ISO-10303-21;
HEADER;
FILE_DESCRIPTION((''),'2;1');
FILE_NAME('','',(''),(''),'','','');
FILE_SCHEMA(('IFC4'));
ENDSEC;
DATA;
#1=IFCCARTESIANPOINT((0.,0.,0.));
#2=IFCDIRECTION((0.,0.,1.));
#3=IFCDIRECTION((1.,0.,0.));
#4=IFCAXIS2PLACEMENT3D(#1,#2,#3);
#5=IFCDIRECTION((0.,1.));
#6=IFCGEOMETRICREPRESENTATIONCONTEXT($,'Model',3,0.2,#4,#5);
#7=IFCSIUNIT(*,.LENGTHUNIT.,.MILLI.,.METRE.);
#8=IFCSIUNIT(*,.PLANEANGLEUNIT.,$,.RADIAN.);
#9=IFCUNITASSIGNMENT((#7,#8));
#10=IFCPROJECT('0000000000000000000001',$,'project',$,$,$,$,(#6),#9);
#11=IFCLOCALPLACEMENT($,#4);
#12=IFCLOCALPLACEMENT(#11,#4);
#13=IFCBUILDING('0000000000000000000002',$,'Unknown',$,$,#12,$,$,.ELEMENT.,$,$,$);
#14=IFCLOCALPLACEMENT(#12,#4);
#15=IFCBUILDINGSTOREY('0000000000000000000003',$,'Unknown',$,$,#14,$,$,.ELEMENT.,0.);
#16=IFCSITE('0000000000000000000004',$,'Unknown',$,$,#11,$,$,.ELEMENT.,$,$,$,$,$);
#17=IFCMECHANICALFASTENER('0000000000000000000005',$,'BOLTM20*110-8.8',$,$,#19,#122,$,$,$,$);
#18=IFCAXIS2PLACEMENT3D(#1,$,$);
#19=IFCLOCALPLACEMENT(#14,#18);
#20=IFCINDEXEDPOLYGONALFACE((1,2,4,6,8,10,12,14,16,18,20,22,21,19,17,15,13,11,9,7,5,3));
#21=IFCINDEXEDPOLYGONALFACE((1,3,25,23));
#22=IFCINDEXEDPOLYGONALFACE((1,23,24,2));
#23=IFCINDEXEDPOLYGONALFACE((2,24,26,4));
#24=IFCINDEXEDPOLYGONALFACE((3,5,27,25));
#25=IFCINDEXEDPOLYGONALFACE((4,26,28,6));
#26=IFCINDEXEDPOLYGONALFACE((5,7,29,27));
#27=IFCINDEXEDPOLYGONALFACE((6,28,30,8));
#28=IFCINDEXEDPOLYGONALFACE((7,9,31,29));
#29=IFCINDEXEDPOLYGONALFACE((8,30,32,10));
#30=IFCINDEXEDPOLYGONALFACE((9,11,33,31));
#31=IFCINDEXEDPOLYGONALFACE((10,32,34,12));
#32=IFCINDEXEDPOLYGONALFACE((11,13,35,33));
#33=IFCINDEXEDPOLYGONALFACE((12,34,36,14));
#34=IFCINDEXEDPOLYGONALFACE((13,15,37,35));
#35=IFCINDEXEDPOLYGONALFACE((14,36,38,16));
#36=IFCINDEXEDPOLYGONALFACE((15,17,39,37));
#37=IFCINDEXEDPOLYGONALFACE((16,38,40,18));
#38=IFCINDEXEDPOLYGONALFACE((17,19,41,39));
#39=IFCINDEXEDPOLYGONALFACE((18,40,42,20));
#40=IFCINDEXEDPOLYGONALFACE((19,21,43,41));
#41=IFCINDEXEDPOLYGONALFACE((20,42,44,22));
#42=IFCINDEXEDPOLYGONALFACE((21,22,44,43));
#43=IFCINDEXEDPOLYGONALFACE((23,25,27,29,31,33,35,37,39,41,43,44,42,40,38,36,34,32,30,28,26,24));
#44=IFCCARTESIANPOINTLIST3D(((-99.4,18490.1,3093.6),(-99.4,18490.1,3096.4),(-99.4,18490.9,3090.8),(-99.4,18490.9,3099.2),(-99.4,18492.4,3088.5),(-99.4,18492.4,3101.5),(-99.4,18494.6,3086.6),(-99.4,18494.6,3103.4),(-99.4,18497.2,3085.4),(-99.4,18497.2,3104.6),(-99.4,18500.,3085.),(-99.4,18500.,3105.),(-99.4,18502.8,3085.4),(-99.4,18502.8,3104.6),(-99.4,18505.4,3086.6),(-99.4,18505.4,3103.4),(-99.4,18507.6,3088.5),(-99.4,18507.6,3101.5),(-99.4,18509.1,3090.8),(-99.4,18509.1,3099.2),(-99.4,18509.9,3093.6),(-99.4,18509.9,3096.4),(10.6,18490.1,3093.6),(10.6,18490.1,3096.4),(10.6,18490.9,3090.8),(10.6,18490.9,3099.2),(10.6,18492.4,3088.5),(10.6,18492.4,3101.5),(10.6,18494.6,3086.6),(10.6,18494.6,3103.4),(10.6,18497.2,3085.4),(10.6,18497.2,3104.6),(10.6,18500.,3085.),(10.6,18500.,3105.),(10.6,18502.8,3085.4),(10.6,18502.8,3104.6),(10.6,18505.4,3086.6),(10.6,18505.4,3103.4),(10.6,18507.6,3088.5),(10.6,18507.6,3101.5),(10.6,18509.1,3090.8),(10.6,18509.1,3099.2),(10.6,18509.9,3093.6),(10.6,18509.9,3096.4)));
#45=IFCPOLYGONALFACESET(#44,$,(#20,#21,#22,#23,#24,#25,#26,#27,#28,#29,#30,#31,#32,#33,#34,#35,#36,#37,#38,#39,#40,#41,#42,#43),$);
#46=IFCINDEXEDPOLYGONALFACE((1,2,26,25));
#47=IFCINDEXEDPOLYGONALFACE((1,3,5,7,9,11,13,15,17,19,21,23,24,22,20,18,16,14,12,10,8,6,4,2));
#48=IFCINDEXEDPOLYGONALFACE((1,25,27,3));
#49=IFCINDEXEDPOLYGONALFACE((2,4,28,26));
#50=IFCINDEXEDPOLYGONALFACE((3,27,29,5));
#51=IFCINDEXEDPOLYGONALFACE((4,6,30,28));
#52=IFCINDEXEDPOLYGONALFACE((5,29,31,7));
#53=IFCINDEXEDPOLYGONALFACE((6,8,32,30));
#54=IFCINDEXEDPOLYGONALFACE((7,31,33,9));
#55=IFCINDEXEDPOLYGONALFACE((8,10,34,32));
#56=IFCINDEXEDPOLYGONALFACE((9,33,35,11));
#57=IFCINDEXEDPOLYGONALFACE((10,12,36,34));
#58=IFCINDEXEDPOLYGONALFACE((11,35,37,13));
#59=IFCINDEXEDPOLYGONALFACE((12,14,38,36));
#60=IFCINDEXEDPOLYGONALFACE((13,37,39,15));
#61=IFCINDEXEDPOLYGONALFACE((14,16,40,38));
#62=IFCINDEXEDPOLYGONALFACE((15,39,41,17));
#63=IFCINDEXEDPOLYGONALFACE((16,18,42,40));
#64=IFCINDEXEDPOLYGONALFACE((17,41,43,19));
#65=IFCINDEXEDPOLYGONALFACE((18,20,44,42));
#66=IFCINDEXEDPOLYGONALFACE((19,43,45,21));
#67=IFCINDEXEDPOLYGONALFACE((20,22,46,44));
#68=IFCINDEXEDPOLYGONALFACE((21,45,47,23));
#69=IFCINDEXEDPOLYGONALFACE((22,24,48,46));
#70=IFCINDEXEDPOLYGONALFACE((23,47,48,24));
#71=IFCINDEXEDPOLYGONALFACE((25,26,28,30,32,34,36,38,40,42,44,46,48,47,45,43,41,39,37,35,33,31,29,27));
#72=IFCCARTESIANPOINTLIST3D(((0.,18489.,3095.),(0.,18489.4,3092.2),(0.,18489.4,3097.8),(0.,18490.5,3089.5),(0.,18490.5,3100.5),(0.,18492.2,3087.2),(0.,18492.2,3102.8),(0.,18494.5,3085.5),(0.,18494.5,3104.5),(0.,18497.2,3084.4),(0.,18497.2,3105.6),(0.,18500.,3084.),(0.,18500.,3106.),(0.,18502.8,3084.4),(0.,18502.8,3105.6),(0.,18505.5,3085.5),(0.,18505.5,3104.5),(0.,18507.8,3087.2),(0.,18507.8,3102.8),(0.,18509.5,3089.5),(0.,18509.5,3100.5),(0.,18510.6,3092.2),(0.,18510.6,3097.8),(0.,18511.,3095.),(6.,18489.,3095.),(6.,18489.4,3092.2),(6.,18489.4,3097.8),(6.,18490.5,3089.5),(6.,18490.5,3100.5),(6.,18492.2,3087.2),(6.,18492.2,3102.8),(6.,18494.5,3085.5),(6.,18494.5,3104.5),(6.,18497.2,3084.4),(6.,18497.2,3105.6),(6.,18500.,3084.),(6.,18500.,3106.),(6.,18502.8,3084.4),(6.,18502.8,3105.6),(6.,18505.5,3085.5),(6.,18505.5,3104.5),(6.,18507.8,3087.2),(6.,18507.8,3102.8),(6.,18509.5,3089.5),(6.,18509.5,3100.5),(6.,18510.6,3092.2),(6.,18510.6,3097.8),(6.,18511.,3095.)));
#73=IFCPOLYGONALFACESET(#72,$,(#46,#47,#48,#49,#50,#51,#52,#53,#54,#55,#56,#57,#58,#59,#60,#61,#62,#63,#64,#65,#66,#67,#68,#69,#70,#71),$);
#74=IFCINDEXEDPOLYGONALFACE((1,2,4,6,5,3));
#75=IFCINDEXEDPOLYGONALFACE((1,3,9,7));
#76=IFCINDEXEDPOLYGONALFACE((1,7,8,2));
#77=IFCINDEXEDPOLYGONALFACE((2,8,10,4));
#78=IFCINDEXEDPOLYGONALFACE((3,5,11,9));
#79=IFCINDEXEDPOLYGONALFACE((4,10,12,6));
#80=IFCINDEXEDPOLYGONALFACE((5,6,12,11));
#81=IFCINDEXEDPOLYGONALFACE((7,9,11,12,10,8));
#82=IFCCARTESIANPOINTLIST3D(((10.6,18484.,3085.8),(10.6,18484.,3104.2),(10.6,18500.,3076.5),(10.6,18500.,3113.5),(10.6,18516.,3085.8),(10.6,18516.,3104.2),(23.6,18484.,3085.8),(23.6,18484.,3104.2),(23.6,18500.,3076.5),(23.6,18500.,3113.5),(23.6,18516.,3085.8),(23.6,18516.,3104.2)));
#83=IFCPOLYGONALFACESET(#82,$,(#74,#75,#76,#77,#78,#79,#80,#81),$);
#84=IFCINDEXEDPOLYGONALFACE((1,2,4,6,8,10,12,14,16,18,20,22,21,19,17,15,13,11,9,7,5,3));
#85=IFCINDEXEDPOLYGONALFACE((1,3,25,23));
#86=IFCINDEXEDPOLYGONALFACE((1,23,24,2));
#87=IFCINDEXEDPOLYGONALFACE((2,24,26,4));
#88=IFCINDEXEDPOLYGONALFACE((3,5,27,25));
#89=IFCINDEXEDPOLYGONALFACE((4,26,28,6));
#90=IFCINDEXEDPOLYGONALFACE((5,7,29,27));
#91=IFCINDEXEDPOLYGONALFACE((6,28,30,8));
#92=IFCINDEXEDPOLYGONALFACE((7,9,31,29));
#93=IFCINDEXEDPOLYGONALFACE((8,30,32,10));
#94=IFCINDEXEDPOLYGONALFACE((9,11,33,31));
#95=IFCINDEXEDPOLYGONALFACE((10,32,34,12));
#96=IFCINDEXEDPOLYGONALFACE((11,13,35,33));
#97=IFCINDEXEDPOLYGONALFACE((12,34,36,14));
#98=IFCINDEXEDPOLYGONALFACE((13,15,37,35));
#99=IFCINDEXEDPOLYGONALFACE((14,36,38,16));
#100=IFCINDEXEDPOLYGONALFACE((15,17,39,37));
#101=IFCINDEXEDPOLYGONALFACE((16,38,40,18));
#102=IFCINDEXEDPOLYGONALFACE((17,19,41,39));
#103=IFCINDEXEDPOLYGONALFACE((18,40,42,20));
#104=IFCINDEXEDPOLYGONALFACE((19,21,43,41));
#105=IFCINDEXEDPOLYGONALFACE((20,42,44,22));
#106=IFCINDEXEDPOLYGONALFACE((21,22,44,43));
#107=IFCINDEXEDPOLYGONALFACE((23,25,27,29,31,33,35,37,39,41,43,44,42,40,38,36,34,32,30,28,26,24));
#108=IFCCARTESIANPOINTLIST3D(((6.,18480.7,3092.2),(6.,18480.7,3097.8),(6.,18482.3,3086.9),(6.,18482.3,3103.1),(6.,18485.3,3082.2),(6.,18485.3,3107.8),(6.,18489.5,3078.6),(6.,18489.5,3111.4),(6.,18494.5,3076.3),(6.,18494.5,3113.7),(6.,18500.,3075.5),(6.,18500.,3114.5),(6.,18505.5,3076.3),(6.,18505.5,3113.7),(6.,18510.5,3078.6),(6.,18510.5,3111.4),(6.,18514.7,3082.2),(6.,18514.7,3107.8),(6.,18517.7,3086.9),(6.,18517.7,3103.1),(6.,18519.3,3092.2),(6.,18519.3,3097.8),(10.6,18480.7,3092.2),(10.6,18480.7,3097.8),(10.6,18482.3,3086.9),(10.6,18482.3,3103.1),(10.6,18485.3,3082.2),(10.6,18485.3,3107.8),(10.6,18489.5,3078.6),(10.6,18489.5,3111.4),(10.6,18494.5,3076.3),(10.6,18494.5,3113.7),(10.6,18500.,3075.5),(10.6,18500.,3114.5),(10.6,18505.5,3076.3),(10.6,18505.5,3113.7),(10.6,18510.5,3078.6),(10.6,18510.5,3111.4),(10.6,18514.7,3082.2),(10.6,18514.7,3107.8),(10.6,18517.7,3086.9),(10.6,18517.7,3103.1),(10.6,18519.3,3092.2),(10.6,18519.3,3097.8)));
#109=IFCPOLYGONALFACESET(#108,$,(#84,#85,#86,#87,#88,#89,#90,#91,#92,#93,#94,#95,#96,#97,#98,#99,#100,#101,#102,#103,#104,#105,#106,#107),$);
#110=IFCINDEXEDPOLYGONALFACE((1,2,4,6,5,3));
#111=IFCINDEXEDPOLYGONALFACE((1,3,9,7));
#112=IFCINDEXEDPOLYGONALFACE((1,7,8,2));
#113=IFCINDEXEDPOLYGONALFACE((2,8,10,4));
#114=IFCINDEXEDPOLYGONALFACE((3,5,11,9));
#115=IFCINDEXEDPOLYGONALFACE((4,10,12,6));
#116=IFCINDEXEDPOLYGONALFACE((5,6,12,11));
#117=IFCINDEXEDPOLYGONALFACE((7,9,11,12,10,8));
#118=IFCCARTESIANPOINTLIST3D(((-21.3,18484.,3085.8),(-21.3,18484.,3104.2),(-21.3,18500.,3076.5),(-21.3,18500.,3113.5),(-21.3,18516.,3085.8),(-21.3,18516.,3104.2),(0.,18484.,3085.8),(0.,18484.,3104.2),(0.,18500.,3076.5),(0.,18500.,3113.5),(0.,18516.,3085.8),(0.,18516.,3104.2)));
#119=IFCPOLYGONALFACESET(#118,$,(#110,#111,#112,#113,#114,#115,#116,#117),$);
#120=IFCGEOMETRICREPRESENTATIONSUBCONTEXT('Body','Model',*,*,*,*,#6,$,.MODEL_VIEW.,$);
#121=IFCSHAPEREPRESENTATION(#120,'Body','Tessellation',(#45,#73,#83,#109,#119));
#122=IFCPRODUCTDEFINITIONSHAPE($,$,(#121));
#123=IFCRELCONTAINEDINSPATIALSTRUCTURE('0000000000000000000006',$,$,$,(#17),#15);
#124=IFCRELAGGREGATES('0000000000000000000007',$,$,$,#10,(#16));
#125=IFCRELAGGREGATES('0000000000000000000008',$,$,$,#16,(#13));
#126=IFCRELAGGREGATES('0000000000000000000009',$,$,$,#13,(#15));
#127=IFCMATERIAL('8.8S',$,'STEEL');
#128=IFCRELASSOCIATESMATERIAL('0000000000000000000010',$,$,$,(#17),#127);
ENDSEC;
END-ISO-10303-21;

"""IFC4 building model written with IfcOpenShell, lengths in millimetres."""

from ifc_helpers import new_model, si_unit, direction, frame, origin_with_axes, place, context, subcontext, project, spatial, line, arc, indexed_curve, outline, extrude, source, transform, mapped, material, element, save


model = new_model("IFC4")

# Units and contexts
model_context = context("Model", 3, precision=0.2, world=origin_with_axes(), true_north=direction((0.0, 1.0)))
body_context = subcontext(model_context, "Body", "Model", "MODEL_VIEW")
ifc_project = project(units=[si_unit("LENGTHUNIT", "METRE", prefix="MILLI"), si_unit("PLANEANGLEUNIT", "RADIAN")], contexts=[model_context])

# Site, building, storey
site_placement = place(None, origin_with_axes())
site = spatial("IfcSite", under=ifc_project, at=site_placement, Name="Unknown", CompositionType="ELEMENT")
building_placement = place(site_placement, origin_with_axes())
building = spatial("IfcBuilding", under=site, at=building_placement, Name="Unknown", CompositionType="ELEMENT")
storey_placement = place(building_placement, origin_with_axes())
storey = spatial("IfcBuildingStorey", under=building, at=storey_placement, Name="Unknown", CompositionType="ELEMENT", Elevation=0.0)

# Mechanical fastener
ifc_material_1 = material(Name="8.8S", Category="STEEL")
shared_shape_1 = source(origin_with_axes(), body_context, "Body", "SweptSolid", [
    extrude(outline(indexed_curve([(10.0, 0.0), (0.0, 10.0), (-10.0, 0.0), (0.0, -10.0)], segments=[arc(1, 2, 3), arc(3, 4, 1)])), frame((0.0, 0.0, 4.6), z_axis=(0.0, 0.0, -1.0), x_axis=(0.0, 1.0, 0.0)), (0.0, 0.0, 1.0), 110.0),
    extrude(outline(indexed_curve([(0.0, 11.0), (7.8, 7.8), (11.0, 0.0), (7.8, -7.8), (0.0, -11.0), (-1.0, -11.0), (-11.0, 0.0), (-7.8, 7.8)], segments=[arc(1, 2, 3), arc(3, 4, 5), arc(5, 6, 7), arc(7, 8, 1)])), frame((0.0, 0.0, 0.0), z_axis=(0.0, 0.0, -1.0), x_axis=(0.0, 1.0, 0.0)), (0.0, 0.0, 1.0), 6.0),
    extrude(outline(indexed_curve([(18.5, 0.0), (9.2, 16.0), (-9.2, 16.0), (-18.5, 0.0), (-9.2, -16.0), (9.2, -16.0)], segments=[line(1, 2, 3, 4, 5, 6, 1)])), frame((0.0, 0.0, 17.6), z_axis=(0.0, 0.0, -1.0), x_axis=(0.0, 1.0, 0.0)), (0.0, 0.0, 1.0), 13.0),
    extrude(outline(indexed_curve([(19.5, 0.0), (0.0, 19.5), (-19.5, 0.0), (0.0, -19.5)], segments=[arc(1, 2, 3), arc(3, 4, 1)])), frame((0.0, 0.0, 4.6), z_axis=(0.0, 0.0, -1.0), x_axis=(0.0, 1.0, 0.0)), (0.0, 0.0, 1.0), 4.6),
    extrude(outline(indexed_curve([(18.5, 0.0), (9.2, 16.0), (-9.2, 16.0), (-18.5, 0.0), (-9.2, -16.0), (9.2, -16.0)], segments=[line(1, 2, 3, 4, 5, 6, 1)])), frame((0.0, 0.0, -6.0), z_axis=(0.0, 0.0, -1.0), x_axis=(0.0, 1.0, 0.0)), (0.0, 0.0, 1.0), 21.3),
])
mechanical_fastener_1_placement = place(storey_placement, frame((6.0, 18500.0, 3095.0), z_axis=(1.0, 0.0, 0.0), x_axis=(0.0, 1.0, 0.0)))
element("IfcMechanicalFastener", 1, at=mechanical_fastener_1_placement, inside=storey, material=ifc_material_1, Name="BOLTM20*110-8.8", context=body_context, shape_type="MappedRepresentation", body=[
    mapped(shared_shape_1, transform((0.0, 0.0, 0.0))),
])

save(model, "model.ifc")
